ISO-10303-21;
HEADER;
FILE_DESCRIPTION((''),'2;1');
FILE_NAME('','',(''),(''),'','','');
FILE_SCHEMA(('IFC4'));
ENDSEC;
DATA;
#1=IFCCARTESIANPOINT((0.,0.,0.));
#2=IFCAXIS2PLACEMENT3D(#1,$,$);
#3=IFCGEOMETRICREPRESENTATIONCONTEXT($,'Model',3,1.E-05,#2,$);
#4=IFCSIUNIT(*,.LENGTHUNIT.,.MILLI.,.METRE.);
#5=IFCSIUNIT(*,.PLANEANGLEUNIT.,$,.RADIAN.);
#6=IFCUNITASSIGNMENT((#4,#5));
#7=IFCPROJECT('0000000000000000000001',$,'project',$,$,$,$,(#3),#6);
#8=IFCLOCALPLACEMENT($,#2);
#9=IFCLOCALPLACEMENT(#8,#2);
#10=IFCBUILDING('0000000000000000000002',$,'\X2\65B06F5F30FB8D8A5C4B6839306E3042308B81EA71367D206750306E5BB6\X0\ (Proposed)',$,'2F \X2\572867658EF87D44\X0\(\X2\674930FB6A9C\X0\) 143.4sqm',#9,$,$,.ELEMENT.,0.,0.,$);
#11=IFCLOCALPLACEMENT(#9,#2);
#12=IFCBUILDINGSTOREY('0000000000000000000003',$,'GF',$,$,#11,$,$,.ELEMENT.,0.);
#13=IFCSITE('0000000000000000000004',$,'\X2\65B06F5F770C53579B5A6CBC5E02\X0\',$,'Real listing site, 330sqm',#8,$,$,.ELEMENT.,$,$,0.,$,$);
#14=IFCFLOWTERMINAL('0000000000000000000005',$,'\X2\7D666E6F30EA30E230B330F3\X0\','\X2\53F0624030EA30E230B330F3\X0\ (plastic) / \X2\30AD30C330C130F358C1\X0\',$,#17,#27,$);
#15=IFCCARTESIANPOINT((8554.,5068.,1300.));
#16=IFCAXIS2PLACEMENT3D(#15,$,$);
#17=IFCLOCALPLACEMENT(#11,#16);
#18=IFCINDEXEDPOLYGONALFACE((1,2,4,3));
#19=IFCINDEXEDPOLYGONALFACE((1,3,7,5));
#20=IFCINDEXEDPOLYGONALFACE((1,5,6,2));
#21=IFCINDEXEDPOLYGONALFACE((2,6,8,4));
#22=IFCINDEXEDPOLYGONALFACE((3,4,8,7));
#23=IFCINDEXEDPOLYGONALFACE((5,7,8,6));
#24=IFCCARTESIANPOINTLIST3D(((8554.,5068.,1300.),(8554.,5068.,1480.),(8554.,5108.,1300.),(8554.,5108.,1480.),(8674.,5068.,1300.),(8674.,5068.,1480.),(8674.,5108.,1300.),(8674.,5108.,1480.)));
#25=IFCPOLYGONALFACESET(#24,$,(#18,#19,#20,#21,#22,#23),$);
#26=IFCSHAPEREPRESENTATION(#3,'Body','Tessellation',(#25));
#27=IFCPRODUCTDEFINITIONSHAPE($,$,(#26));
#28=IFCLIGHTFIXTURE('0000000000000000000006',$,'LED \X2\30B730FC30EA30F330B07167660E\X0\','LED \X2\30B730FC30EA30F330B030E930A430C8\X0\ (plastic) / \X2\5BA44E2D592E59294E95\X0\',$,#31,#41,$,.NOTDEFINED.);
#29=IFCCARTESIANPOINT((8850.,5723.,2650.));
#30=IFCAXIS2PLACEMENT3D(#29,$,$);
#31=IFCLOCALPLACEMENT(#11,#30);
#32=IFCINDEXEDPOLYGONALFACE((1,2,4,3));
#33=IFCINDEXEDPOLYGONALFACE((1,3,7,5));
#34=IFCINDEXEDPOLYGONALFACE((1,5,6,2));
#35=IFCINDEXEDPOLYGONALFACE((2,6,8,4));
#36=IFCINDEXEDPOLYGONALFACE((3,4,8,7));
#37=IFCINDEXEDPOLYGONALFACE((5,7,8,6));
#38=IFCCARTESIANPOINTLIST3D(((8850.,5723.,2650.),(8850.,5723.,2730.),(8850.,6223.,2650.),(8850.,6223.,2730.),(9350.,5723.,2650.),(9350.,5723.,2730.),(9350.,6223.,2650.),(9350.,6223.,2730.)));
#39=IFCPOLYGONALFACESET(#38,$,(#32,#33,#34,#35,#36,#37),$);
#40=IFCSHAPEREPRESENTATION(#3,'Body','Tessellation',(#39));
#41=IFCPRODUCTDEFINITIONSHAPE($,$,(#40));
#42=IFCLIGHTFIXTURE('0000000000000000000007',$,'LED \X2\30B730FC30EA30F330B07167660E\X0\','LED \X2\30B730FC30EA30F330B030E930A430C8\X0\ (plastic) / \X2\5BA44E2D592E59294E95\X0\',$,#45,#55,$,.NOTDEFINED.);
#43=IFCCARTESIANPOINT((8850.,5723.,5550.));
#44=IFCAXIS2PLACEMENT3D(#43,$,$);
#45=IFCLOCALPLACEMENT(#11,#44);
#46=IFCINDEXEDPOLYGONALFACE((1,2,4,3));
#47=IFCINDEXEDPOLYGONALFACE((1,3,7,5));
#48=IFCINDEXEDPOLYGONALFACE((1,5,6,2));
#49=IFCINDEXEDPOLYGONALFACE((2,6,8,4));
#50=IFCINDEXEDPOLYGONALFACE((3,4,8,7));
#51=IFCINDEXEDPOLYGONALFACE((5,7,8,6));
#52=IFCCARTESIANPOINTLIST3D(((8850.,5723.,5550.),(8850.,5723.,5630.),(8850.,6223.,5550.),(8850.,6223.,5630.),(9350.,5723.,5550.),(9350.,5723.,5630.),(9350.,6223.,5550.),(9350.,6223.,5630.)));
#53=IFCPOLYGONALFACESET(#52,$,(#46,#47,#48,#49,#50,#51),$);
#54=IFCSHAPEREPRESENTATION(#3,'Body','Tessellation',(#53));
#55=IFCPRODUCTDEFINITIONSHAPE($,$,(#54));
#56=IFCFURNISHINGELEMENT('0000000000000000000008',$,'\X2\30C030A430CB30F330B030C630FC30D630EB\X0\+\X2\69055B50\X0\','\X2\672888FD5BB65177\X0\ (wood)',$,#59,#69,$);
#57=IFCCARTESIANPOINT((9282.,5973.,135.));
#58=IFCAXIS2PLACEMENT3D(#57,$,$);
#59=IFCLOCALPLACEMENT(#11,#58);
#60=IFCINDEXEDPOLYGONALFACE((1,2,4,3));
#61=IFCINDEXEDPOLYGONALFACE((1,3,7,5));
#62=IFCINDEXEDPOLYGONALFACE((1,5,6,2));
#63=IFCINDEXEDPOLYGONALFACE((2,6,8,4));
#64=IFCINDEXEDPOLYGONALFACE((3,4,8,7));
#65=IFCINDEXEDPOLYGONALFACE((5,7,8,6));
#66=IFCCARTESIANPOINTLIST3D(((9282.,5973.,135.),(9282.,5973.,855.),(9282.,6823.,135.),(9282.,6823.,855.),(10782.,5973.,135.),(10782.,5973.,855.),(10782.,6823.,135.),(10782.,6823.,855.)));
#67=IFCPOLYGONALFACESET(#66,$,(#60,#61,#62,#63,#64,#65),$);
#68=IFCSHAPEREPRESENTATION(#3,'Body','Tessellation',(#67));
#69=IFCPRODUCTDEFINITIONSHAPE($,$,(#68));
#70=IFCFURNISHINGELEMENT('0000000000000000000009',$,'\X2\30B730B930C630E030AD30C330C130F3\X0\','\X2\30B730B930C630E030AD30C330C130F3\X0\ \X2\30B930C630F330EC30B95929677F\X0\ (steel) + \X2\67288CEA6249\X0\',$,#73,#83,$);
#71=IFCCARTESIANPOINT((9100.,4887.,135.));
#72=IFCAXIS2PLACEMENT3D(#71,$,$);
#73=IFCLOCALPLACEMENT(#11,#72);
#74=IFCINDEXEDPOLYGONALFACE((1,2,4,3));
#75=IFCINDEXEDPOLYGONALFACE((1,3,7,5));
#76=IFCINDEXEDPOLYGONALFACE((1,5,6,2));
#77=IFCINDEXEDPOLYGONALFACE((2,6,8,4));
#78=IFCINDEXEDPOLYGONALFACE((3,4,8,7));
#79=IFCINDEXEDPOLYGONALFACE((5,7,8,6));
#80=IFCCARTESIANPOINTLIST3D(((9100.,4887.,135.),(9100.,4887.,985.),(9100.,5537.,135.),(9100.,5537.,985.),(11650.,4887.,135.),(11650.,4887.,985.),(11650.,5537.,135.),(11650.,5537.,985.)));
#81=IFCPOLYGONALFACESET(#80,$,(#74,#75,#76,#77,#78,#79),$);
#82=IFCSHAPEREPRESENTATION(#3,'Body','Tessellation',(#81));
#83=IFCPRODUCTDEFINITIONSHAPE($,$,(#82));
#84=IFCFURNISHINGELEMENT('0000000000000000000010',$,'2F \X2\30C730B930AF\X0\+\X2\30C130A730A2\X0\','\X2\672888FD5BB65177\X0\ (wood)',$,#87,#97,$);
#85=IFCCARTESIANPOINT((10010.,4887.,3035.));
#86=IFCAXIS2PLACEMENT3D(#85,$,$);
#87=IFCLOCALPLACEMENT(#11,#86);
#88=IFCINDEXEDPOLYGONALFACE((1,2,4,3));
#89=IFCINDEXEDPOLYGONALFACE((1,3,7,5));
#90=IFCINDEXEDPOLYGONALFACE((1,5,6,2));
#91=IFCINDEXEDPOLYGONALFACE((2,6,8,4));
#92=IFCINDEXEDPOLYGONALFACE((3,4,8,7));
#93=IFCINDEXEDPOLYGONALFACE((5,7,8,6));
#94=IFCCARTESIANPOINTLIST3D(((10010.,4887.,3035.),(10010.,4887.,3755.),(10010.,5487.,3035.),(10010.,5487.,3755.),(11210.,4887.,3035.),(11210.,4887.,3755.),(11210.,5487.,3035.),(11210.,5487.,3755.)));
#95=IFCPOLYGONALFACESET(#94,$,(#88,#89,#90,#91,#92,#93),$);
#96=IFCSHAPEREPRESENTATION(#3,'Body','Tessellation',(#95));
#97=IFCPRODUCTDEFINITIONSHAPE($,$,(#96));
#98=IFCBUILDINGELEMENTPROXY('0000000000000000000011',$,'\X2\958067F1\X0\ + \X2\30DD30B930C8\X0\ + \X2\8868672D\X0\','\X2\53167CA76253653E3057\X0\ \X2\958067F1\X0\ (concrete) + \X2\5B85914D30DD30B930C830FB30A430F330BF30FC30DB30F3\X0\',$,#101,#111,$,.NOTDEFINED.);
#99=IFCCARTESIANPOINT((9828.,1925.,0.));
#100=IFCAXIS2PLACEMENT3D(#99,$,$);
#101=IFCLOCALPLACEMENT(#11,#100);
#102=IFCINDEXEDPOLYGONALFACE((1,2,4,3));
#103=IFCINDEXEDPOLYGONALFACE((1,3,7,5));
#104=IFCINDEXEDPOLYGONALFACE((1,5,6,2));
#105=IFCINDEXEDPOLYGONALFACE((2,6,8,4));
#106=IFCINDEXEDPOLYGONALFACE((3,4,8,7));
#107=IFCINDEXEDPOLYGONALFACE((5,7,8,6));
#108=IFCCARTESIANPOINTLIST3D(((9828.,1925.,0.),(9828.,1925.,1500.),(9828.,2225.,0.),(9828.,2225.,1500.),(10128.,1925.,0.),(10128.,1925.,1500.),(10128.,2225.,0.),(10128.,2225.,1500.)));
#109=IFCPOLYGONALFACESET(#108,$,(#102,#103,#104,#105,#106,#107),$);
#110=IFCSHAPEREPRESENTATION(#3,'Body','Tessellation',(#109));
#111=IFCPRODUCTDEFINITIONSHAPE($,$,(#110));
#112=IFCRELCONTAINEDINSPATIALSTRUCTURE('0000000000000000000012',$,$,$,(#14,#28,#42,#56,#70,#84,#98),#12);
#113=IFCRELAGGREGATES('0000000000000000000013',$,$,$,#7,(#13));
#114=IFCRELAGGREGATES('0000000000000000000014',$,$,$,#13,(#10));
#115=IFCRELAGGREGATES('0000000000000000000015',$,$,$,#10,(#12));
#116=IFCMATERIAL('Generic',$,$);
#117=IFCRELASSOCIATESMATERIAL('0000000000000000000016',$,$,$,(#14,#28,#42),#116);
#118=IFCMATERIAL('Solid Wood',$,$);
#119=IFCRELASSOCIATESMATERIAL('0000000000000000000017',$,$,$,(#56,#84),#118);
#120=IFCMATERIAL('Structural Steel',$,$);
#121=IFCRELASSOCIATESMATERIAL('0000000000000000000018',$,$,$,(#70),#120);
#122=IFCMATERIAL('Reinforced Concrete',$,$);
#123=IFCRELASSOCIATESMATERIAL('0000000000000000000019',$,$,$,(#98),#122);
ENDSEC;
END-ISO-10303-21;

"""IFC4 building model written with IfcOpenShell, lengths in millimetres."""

from ifc_helpers import new_model, si_unit, frame, frame_2d, origin, place, context, project, spatial, rectangle, extrude, material, element, save


model = new_model("IFC4")

# Units and contexts
model_context = context("Model", 3, precision=1e-05, world=origin())
ifc_project = project(units=[si_unit("LENGTHUNIT", "METRE", prefix="MILLI"), si_unit("PLANEANGLEUNIT", "RADIAN")], contexts=[model_context])

# Site, building, storey
site_placement = place(None, origin())
site = spatial("IfcSite", under=ifc_project, at=site_placement, Name="新潟県南魚沼市", ObjectType="Real listing site, 330sqm", CompositionType="ELEMENT", RefElevation=0.0)
building_placement = place(site_placement, origin())
building = spatial("IfcBuilding", under=site, at=building_placement, Name="新潟・越屋根のある自然素材の家 (Proposed)", ObjectType="2F 在来軸組(杉・檜) 143.4sqm", CompositionType="ELEMENT", ElevationOfRefHeight=0.0, ElevationOfTerrain=0.0)
storey_placement = place(building_placement, origin())
storey = spatial("IfcBuildingStorey", under=building, at=storey_placement, Name="GF", CompositionType="ELEMENT", Elevation=0.0)

# Shared definitions
ifc_material_1 = material(Name="Solid Wood")

# Shared definitions
ifc_material_2 = material(Name="Reinforced Concrete")

# Shared definitions
ifc_material_3 = material(Name="Structural Steel")

# Flow terminal
ifc_material_4 = material(Name="Generic")
flow_terminal_1_placement = place(storey_placement, frame((8554.0, 5068.0, 1300.0)))
element("IfcFlowTerminal", 1, at=flow_terminal_1_placement, inside=storey, material=ifc_material_4, Name="給湯リモコン", Description="台所リモコン (plastic) / キッチン壁", context=model_context, shape_type="SweptSolid", body=[
    extrude(rectangle(XDim=120.0, YDim=40.0, at=frame_2d((60.0, 20.0))), frame((8554.0, 5068.0, 1300.0)), (0.0, 0.0, 1.0), 180.0),
])

# Light fixtures
light_fixture_1_placement = place(storey_placement, frame((8850.0, 5723.0, 2650.0)))
element("IfcLightFixture", 2, at=light_fixture_1_placement, inside=storey, material=ifc_material_4, Name="LED シーリング照明", Description="LED シーリングライト (plastic) / 室中央天井", PredefinedType="NOTDEFINED", context=model_context, shape_type="SweptSolid", body=[
    extrude(rectangle(XDim=500.0, YDim=500.0, at=frame_2d((250.0, 250.0))), frame((8850.0, 5723.0, 2650.0)), (0.0, 0.0, 1.0), 80.0),
])
light_fixture_2_placement = place(storey_placement, frame((8850.0, 5723.0, 5550.0)))
element("IfcLightFixture", 3, at=light_fixture_2_placement, inside=storey, material=ifc_material_4, Name="LED シーリング照明", Description="LED シーリングライト (plastic) / 室中央天井", PredefinedType="NOTDEFINED", context=model_context, shape_type="SweptSolid", body=[
    extrude(rectangle(XDim=500.0, YDim=500.0, at=frame_2d((250.0, 250.0))), frame((8850.0, 5723.0, 5550.0)), (0.0, 0.0, 1.0), 80.0),
])

# Furnishing elements
furnishing_1_placement = place(storey_placement, frame((9282.0, 5973.0, 135.0)))
element("IfcFurnishingElement", 4, at=furnishing_1_placement, inside=storey, material=ifc_material_1, Name="ダイニングテーブル+椅子", Description="木製家具 (wood)", context=model_context, shape_type="SweptSolid", body=[
    extrude(rectangle(XDim=1500.0, YDim=850.0, at=frame_2d((750.0, 425.0))), frame((9282.0, 5973.0, 135.0)), (0.0, 0.0, 1.0), 720.0),
])
furnishing_2_placement = place(storey_placement, frame((9100.0, 4887.0, 135.0)))
element("IfcFurnishingElement", 5, at=furnishing_2_placement, inside=storey, material=ifc_material_3, Name="システムキッチン", Description="システムキッチン ステンレス天板 (steel) + 木質扉", context=model_context, shape_type="SweptSolid", body=[
    extrude(rectangle(XDim=2550.0, YDim=650.0, at=frame_2d((1275.0, 325.0))), frame((9100.0, 4887.0, 135.0)), (0.0, 0.0, 1.0), 850.0),
])
furnishing_3_placement = place(storey_placement, frame((10010.0, 4887.0, 3035.0)))
element("IfcFurnishingElement", 6, at=furnishing_3_placement, inside=storey, material=ifc_material_1, Name="2F デスク+チェア", Description="木製家具 (wood)", context=model_context, shape_type="SweptSolid", body=[
    extrude(rectangle(XDim=1200.0, YDim=600.0, at=frame_2d((600.0, 300.0))), frame((10010.0, 4887.0, 3035.0)), (0.0, 0.0, 1.0), 720.0),
])

# Building element proxy
proxy_placement = place(storey_placement, frame((9828.0, 1925.0, 0.0)))
element("IfcBuildingElementProxy", 7, at=proxy_placement, inside=storey, material=ifc_material_2, Name="門柱 + ポスト + 表札", Description="化粧打放し 門柱 (concrete) + 宅配ポスト・インターホン", PredefinedType="NOTDEFINED", context=model_context, shape_type="SweptSolid", body=[
    extrude(rectangle(XDim=300.0, YDim=300.0, at=frame_2d((150.0, 150.0))), frame((9828.0, 1925.0, 0.0)), (0.0, 0.0, 1.0), 1500.0),
])

save(model, "model.ifc")
